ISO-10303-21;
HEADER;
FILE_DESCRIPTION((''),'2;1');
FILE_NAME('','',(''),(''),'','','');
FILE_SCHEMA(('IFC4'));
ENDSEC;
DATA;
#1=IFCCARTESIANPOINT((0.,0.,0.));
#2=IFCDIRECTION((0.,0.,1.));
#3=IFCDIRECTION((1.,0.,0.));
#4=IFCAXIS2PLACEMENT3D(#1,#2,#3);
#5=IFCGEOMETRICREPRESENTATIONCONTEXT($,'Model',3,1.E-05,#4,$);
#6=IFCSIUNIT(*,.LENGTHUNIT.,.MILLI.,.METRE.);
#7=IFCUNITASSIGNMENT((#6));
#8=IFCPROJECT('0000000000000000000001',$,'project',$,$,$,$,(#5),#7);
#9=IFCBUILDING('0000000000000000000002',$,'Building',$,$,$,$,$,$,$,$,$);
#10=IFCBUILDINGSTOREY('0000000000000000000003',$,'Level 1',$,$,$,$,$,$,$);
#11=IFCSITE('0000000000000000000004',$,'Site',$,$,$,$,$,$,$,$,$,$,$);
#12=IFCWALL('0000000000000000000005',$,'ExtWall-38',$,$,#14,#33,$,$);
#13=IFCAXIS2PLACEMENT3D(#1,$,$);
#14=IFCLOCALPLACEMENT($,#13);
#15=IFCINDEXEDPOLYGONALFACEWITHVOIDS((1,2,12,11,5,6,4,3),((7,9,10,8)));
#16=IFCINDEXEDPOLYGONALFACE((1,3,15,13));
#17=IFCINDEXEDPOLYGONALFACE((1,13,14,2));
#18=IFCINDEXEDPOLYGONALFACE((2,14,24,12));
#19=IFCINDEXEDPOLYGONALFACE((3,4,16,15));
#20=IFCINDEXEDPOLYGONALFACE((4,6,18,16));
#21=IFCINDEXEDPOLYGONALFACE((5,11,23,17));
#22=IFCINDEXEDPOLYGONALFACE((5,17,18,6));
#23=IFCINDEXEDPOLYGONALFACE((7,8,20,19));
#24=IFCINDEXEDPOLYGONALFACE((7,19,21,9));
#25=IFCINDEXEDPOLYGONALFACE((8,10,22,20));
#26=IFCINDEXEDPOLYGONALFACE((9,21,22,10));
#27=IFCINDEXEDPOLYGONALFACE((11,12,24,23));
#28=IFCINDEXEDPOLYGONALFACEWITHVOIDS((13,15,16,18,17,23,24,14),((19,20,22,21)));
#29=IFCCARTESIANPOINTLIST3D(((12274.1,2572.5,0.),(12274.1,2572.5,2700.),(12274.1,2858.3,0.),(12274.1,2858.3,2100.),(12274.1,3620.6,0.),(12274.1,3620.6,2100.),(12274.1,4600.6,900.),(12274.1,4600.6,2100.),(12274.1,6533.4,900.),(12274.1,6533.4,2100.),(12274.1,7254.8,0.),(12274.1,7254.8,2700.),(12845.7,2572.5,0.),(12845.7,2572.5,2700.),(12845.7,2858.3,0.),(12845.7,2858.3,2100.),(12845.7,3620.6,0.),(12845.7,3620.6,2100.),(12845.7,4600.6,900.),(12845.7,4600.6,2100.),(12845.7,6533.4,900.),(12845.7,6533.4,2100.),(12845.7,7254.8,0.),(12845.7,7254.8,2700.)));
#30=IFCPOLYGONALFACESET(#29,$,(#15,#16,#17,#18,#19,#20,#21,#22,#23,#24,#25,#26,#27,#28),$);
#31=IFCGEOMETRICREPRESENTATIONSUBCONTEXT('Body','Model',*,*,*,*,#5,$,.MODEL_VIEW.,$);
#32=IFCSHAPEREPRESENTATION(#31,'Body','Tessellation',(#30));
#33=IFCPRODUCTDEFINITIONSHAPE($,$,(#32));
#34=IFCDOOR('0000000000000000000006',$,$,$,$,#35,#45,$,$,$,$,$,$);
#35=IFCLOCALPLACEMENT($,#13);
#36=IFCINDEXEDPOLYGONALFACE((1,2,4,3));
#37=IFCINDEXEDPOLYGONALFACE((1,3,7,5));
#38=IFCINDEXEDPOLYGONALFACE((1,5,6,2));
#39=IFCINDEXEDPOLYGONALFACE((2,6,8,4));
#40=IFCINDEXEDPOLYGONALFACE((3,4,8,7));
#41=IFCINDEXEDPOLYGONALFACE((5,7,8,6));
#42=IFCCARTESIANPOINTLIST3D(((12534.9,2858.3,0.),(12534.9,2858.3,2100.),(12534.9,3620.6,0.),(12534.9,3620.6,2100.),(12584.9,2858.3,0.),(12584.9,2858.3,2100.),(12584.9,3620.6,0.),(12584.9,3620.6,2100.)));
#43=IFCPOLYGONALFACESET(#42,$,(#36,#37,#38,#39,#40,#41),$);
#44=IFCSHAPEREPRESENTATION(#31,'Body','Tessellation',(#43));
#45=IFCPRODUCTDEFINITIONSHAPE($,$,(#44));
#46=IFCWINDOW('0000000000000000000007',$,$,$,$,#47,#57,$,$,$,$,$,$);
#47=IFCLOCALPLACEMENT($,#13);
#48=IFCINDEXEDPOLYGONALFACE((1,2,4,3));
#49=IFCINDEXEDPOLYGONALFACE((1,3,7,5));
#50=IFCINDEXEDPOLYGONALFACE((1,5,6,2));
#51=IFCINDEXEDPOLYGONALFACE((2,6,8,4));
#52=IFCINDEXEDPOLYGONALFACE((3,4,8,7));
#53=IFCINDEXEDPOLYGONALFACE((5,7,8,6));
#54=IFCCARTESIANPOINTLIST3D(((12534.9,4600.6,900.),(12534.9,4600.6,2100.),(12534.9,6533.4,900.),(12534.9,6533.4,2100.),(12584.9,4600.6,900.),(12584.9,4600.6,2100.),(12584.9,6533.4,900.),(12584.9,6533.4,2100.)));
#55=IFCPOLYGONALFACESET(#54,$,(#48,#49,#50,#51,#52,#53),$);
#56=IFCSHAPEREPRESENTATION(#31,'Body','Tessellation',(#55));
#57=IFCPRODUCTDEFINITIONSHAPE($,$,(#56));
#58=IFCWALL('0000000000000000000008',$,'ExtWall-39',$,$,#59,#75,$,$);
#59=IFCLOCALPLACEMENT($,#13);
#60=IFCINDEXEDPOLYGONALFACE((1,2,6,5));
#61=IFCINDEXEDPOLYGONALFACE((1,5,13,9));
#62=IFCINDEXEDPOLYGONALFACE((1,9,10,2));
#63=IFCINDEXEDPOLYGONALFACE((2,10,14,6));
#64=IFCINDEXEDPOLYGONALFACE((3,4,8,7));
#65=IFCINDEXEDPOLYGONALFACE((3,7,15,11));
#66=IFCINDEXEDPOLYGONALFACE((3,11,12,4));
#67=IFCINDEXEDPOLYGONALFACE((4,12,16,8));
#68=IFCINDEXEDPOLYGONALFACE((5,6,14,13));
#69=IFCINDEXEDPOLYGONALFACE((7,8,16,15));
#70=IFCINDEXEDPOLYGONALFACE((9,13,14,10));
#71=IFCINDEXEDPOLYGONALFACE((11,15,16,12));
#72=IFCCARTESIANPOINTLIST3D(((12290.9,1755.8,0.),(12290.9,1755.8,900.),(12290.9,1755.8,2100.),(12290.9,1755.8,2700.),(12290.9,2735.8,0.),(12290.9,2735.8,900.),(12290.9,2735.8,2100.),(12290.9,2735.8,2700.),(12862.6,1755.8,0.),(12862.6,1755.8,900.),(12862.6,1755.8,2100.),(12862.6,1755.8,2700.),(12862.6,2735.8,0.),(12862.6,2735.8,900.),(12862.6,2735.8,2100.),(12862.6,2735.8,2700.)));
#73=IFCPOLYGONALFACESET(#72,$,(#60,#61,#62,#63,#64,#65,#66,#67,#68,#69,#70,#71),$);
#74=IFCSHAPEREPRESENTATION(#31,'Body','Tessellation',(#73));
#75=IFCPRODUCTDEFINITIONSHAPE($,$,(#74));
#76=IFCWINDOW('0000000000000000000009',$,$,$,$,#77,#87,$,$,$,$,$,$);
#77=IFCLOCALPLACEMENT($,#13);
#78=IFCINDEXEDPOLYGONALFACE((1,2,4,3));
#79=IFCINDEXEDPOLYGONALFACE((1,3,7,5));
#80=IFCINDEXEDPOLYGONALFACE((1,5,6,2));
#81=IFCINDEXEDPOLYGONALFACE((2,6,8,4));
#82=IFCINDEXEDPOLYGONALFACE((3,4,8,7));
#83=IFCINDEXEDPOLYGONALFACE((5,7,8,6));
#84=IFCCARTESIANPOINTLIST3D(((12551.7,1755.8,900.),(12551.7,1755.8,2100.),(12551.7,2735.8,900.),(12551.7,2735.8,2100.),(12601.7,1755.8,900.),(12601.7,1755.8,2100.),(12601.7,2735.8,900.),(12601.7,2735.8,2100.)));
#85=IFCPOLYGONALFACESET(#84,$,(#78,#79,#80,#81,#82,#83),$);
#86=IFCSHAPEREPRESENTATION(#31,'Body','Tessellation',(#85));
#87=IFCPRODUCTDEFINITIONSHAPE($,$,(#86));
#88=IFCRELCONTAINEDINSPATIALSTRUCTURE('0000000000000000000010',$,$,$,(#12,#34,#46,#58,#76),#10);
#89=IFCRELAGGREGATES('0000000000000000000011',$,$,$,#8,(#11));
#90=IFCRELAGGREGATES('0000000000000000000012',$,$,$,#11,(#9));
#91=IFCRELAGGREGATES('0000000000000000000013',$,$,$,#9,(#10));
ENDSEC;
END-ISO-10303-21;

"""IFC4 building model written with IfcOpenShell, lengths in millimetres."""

from ifc_helpers import new_model, si_unit, frame, origin_with_axes, place, context, subcontext, project, spatial, indexed_curve, outline, extrude, element, fill, save


model = new_model("IFC4")

# Units and contexts
model_context = context("Model", 3, precision=1e-05, world=origin_with_axes())
body_context = subcontext(model_context, "Body", "Model", "MODEL_VIEW")
ifc_project = project(units=[si_unit("LENGTHUNIT", "METRE", prefix="MILLI")], contexts=[model_context])

# Site, building, storey
site = spatial("IfcSite", under=ifc_project, Name="Site")
building = spatial("IfcBuilding", under=site, Name="Building")
storey = spatial("IfcBuildingStorey", under=building, Name="Level 1")

# Wall, openings, door, window
wall_1_placement = place(None, frame((12559.9, 2572.5, 0.0), z_axis=(0.0, 0.0, 1.0), x_axis=(0.0, 1.0, 0.0)))
wall_1 = element("IfcWall", 1, at=wall_1_placement, inside=storey, Name="ExtWall-38", context=body_context, shape_type="SweptSolid", body=[
    extrude(outline(indexed_curve([(0.0, 0.0), (0.0, 571.7), (4682.2, 571.7), (4682.2, 0.0), (0.0, 0.0)], self_intersect=False)), frame((0.0, -285.8, 0.0), z_axis=(0.0, 0.0, 1.0), x_axis=(1.0, 0.0, 0.0)), (0.0, 0.0, 1.0), 2700.0),
])
opening_1_placement = place(wall_1_placement, frame((285.8, 0.0, 0.0), z_axis=(0.0, 0.0, 1.0), x_axis=(1.0, 0.0, 0.0)))
opening_1 = element("IfcOpeningElement", 2, at=opening_1_placement, cuts=wall_1, context=body_context, shape_type="SweptSolid", body=[
    extrude(outline(indexed_curve([(0.0, 0.0), (0.0, 671.7), (762.2, 671.7), (762.2, 0.0), (0.0, 0.0)], self_intersect=False)), frame((0.0, -335.8, 0.0), z_axis=(0.0, 0.0, 1.0), x_axis=(1.0, 0.0, 0.0)), (0.0, 0.0, 1.0), 2100.0),
])
opening_2_placement = place(wall_1_placement, frame((2028.1, 0.0, 900.0), z_axis=(0.0, 0.0, 1.0), x_axis=(1.0, 0.0, 0.0)))
opening_2 = element("IfcOpeningElement", 3, at=opening_2_placement, cuts=wall_1, context=body_context, shape_type="SweptSolid", body=[
    extrude(outline(indexed_curve([(0.0, 0.0), (0.0, 671.7), (1932.8, 671.7), (1932.8, 0.0), (0.0, 0.0)], self_intersect=False)), frame((0.0, -335.8, 0.0), z_axis=(0.0, 0.0, 1.0), x_axis=(1.0, 0.0, 0.0)), (0.0, 0.0, 1.0), 1200.0),
])
door_1_placement = place(opening_1_placement, frame((0.0, 0.0, 0.0), z_axis=(0.0, 0.0, 1.0), x_axis=(1.0, 0.0, 0.0)))
door_1 = element("IfcDoor", 4, at=door_1_placement, inside=storey, context=body_context, shape_type="SweptSolid", body=[
    extrude(outline(indexed_curve([(0.0, 0.0), (0.0, 50.0), (762.2, 50.0), (762.2, 0.0), (0.0, 0.0)], self_intersect=False)), frame((0.0, -25.0, 0.0), z_axis=(0.0, 0.0, 1.0), x_axis=(1.0, 0.0, 0.0)), (0.0, 0.0, 1.0), 2100.0),
])
fill(opening_1, door_1)
window_1_placement = place(opening_2_placement, frame((0.0, 0.0, 0.0), z_axis=(0.0, 0.0, 1.0), x_axis=(1.0, 0.0, 0.0)))
window_1 = element("IfcWindow", 5, at=window_1_placement, inside=storey, context=body_context, shape_type="SweptSolid", body=[
    extrude(outline(indexed_curve([(0.0, 0.0), (0.0, 50.0), (1932.8, 50.0), (1932.8, 0.0), (0.0, 0.0)], self_intersect=False)), frame((0.0, -25.0, 0.0), z_axis=(0.0, 0.0, 1.0), x_axis=(1.0, 0.0, 0.0)), (0.0, 0.0, 1.0), 1200.0),
])
fill(opening_2, window_1)

# Wall, opening, window
wall_2_placement = place(None, frame((12576.7, 1755.8, 0.0), z_axis=(0.0, 0.0, 1.0), x_axis=(0.0, 1.0, 0.0)))
wall_2 = element("IfcWall", 6, at=wall_2_placement, inside=storey, Name="ExtWall-39", context=body_context, shape_type="SweptSolid", body=[
    extrude(outline(indexed_curve([(0.0, 0.0), (0.0, 571.7), (980.0, 571.7), (980.0, 0.0), (0.0, 0.0)], self_intersect=False)), frame((0.0, -285.8, 0.0), z_axis=(0.0, 0.0, 1.0), x_axis=(1.0, 0.0, 0.0)), (0.0, 0.0, 1.0), 2700.0),
])
opening_3_placement = place(wall_2_placement, frame((0.0, 0.0, 900.0), z_axis=(0.0, 0.0, 1.0), x_axis=(1.0, 0.0, 0.0)))
opening_3 = element("IfcOpeningElement", 7, at=opening_3_placement, cuts=wall_2, context=body_context, shape_type="SweptSolid", body=[
    extrude(outline(indexed_curve([(0.0, 0.0), (0.0, 671.7), (980.0, 671.7), (980.0, 0.0), (0.0, 0.0)], self_intersect=False)), frame((0.0, -335.8, 0.0), z_axis=(0.0, 0.0, 1.0), x_axis=(1.0, 0.0, 0.0)), (0.0, 0.0, 1.0), 1200.0),
])
window_2_placement = place(opening_3_placement, origin_with_axes())
window_2 = element("IfcWindow", 8, at=window_2_placement, inside=storey, context=body_context, shape_type="SweptSolid", body=[
    extrude(outline(indexed_curve([(0.0, 0.0), (0.0, 50.0), (980.0, 50.0), (980.0, 0.0), (0.0, 0.0)], self_intersect=False)), frame((0.0, -25.0, 0.0), z_axis=(0.0, 0.0, 1.0), x_axis=(1.0, 0.0, 0.0)), (0.0, 0.0, 1.0), 1200.0),
])
fill(opening_3, window_2)

save(model, "model.ifc")
